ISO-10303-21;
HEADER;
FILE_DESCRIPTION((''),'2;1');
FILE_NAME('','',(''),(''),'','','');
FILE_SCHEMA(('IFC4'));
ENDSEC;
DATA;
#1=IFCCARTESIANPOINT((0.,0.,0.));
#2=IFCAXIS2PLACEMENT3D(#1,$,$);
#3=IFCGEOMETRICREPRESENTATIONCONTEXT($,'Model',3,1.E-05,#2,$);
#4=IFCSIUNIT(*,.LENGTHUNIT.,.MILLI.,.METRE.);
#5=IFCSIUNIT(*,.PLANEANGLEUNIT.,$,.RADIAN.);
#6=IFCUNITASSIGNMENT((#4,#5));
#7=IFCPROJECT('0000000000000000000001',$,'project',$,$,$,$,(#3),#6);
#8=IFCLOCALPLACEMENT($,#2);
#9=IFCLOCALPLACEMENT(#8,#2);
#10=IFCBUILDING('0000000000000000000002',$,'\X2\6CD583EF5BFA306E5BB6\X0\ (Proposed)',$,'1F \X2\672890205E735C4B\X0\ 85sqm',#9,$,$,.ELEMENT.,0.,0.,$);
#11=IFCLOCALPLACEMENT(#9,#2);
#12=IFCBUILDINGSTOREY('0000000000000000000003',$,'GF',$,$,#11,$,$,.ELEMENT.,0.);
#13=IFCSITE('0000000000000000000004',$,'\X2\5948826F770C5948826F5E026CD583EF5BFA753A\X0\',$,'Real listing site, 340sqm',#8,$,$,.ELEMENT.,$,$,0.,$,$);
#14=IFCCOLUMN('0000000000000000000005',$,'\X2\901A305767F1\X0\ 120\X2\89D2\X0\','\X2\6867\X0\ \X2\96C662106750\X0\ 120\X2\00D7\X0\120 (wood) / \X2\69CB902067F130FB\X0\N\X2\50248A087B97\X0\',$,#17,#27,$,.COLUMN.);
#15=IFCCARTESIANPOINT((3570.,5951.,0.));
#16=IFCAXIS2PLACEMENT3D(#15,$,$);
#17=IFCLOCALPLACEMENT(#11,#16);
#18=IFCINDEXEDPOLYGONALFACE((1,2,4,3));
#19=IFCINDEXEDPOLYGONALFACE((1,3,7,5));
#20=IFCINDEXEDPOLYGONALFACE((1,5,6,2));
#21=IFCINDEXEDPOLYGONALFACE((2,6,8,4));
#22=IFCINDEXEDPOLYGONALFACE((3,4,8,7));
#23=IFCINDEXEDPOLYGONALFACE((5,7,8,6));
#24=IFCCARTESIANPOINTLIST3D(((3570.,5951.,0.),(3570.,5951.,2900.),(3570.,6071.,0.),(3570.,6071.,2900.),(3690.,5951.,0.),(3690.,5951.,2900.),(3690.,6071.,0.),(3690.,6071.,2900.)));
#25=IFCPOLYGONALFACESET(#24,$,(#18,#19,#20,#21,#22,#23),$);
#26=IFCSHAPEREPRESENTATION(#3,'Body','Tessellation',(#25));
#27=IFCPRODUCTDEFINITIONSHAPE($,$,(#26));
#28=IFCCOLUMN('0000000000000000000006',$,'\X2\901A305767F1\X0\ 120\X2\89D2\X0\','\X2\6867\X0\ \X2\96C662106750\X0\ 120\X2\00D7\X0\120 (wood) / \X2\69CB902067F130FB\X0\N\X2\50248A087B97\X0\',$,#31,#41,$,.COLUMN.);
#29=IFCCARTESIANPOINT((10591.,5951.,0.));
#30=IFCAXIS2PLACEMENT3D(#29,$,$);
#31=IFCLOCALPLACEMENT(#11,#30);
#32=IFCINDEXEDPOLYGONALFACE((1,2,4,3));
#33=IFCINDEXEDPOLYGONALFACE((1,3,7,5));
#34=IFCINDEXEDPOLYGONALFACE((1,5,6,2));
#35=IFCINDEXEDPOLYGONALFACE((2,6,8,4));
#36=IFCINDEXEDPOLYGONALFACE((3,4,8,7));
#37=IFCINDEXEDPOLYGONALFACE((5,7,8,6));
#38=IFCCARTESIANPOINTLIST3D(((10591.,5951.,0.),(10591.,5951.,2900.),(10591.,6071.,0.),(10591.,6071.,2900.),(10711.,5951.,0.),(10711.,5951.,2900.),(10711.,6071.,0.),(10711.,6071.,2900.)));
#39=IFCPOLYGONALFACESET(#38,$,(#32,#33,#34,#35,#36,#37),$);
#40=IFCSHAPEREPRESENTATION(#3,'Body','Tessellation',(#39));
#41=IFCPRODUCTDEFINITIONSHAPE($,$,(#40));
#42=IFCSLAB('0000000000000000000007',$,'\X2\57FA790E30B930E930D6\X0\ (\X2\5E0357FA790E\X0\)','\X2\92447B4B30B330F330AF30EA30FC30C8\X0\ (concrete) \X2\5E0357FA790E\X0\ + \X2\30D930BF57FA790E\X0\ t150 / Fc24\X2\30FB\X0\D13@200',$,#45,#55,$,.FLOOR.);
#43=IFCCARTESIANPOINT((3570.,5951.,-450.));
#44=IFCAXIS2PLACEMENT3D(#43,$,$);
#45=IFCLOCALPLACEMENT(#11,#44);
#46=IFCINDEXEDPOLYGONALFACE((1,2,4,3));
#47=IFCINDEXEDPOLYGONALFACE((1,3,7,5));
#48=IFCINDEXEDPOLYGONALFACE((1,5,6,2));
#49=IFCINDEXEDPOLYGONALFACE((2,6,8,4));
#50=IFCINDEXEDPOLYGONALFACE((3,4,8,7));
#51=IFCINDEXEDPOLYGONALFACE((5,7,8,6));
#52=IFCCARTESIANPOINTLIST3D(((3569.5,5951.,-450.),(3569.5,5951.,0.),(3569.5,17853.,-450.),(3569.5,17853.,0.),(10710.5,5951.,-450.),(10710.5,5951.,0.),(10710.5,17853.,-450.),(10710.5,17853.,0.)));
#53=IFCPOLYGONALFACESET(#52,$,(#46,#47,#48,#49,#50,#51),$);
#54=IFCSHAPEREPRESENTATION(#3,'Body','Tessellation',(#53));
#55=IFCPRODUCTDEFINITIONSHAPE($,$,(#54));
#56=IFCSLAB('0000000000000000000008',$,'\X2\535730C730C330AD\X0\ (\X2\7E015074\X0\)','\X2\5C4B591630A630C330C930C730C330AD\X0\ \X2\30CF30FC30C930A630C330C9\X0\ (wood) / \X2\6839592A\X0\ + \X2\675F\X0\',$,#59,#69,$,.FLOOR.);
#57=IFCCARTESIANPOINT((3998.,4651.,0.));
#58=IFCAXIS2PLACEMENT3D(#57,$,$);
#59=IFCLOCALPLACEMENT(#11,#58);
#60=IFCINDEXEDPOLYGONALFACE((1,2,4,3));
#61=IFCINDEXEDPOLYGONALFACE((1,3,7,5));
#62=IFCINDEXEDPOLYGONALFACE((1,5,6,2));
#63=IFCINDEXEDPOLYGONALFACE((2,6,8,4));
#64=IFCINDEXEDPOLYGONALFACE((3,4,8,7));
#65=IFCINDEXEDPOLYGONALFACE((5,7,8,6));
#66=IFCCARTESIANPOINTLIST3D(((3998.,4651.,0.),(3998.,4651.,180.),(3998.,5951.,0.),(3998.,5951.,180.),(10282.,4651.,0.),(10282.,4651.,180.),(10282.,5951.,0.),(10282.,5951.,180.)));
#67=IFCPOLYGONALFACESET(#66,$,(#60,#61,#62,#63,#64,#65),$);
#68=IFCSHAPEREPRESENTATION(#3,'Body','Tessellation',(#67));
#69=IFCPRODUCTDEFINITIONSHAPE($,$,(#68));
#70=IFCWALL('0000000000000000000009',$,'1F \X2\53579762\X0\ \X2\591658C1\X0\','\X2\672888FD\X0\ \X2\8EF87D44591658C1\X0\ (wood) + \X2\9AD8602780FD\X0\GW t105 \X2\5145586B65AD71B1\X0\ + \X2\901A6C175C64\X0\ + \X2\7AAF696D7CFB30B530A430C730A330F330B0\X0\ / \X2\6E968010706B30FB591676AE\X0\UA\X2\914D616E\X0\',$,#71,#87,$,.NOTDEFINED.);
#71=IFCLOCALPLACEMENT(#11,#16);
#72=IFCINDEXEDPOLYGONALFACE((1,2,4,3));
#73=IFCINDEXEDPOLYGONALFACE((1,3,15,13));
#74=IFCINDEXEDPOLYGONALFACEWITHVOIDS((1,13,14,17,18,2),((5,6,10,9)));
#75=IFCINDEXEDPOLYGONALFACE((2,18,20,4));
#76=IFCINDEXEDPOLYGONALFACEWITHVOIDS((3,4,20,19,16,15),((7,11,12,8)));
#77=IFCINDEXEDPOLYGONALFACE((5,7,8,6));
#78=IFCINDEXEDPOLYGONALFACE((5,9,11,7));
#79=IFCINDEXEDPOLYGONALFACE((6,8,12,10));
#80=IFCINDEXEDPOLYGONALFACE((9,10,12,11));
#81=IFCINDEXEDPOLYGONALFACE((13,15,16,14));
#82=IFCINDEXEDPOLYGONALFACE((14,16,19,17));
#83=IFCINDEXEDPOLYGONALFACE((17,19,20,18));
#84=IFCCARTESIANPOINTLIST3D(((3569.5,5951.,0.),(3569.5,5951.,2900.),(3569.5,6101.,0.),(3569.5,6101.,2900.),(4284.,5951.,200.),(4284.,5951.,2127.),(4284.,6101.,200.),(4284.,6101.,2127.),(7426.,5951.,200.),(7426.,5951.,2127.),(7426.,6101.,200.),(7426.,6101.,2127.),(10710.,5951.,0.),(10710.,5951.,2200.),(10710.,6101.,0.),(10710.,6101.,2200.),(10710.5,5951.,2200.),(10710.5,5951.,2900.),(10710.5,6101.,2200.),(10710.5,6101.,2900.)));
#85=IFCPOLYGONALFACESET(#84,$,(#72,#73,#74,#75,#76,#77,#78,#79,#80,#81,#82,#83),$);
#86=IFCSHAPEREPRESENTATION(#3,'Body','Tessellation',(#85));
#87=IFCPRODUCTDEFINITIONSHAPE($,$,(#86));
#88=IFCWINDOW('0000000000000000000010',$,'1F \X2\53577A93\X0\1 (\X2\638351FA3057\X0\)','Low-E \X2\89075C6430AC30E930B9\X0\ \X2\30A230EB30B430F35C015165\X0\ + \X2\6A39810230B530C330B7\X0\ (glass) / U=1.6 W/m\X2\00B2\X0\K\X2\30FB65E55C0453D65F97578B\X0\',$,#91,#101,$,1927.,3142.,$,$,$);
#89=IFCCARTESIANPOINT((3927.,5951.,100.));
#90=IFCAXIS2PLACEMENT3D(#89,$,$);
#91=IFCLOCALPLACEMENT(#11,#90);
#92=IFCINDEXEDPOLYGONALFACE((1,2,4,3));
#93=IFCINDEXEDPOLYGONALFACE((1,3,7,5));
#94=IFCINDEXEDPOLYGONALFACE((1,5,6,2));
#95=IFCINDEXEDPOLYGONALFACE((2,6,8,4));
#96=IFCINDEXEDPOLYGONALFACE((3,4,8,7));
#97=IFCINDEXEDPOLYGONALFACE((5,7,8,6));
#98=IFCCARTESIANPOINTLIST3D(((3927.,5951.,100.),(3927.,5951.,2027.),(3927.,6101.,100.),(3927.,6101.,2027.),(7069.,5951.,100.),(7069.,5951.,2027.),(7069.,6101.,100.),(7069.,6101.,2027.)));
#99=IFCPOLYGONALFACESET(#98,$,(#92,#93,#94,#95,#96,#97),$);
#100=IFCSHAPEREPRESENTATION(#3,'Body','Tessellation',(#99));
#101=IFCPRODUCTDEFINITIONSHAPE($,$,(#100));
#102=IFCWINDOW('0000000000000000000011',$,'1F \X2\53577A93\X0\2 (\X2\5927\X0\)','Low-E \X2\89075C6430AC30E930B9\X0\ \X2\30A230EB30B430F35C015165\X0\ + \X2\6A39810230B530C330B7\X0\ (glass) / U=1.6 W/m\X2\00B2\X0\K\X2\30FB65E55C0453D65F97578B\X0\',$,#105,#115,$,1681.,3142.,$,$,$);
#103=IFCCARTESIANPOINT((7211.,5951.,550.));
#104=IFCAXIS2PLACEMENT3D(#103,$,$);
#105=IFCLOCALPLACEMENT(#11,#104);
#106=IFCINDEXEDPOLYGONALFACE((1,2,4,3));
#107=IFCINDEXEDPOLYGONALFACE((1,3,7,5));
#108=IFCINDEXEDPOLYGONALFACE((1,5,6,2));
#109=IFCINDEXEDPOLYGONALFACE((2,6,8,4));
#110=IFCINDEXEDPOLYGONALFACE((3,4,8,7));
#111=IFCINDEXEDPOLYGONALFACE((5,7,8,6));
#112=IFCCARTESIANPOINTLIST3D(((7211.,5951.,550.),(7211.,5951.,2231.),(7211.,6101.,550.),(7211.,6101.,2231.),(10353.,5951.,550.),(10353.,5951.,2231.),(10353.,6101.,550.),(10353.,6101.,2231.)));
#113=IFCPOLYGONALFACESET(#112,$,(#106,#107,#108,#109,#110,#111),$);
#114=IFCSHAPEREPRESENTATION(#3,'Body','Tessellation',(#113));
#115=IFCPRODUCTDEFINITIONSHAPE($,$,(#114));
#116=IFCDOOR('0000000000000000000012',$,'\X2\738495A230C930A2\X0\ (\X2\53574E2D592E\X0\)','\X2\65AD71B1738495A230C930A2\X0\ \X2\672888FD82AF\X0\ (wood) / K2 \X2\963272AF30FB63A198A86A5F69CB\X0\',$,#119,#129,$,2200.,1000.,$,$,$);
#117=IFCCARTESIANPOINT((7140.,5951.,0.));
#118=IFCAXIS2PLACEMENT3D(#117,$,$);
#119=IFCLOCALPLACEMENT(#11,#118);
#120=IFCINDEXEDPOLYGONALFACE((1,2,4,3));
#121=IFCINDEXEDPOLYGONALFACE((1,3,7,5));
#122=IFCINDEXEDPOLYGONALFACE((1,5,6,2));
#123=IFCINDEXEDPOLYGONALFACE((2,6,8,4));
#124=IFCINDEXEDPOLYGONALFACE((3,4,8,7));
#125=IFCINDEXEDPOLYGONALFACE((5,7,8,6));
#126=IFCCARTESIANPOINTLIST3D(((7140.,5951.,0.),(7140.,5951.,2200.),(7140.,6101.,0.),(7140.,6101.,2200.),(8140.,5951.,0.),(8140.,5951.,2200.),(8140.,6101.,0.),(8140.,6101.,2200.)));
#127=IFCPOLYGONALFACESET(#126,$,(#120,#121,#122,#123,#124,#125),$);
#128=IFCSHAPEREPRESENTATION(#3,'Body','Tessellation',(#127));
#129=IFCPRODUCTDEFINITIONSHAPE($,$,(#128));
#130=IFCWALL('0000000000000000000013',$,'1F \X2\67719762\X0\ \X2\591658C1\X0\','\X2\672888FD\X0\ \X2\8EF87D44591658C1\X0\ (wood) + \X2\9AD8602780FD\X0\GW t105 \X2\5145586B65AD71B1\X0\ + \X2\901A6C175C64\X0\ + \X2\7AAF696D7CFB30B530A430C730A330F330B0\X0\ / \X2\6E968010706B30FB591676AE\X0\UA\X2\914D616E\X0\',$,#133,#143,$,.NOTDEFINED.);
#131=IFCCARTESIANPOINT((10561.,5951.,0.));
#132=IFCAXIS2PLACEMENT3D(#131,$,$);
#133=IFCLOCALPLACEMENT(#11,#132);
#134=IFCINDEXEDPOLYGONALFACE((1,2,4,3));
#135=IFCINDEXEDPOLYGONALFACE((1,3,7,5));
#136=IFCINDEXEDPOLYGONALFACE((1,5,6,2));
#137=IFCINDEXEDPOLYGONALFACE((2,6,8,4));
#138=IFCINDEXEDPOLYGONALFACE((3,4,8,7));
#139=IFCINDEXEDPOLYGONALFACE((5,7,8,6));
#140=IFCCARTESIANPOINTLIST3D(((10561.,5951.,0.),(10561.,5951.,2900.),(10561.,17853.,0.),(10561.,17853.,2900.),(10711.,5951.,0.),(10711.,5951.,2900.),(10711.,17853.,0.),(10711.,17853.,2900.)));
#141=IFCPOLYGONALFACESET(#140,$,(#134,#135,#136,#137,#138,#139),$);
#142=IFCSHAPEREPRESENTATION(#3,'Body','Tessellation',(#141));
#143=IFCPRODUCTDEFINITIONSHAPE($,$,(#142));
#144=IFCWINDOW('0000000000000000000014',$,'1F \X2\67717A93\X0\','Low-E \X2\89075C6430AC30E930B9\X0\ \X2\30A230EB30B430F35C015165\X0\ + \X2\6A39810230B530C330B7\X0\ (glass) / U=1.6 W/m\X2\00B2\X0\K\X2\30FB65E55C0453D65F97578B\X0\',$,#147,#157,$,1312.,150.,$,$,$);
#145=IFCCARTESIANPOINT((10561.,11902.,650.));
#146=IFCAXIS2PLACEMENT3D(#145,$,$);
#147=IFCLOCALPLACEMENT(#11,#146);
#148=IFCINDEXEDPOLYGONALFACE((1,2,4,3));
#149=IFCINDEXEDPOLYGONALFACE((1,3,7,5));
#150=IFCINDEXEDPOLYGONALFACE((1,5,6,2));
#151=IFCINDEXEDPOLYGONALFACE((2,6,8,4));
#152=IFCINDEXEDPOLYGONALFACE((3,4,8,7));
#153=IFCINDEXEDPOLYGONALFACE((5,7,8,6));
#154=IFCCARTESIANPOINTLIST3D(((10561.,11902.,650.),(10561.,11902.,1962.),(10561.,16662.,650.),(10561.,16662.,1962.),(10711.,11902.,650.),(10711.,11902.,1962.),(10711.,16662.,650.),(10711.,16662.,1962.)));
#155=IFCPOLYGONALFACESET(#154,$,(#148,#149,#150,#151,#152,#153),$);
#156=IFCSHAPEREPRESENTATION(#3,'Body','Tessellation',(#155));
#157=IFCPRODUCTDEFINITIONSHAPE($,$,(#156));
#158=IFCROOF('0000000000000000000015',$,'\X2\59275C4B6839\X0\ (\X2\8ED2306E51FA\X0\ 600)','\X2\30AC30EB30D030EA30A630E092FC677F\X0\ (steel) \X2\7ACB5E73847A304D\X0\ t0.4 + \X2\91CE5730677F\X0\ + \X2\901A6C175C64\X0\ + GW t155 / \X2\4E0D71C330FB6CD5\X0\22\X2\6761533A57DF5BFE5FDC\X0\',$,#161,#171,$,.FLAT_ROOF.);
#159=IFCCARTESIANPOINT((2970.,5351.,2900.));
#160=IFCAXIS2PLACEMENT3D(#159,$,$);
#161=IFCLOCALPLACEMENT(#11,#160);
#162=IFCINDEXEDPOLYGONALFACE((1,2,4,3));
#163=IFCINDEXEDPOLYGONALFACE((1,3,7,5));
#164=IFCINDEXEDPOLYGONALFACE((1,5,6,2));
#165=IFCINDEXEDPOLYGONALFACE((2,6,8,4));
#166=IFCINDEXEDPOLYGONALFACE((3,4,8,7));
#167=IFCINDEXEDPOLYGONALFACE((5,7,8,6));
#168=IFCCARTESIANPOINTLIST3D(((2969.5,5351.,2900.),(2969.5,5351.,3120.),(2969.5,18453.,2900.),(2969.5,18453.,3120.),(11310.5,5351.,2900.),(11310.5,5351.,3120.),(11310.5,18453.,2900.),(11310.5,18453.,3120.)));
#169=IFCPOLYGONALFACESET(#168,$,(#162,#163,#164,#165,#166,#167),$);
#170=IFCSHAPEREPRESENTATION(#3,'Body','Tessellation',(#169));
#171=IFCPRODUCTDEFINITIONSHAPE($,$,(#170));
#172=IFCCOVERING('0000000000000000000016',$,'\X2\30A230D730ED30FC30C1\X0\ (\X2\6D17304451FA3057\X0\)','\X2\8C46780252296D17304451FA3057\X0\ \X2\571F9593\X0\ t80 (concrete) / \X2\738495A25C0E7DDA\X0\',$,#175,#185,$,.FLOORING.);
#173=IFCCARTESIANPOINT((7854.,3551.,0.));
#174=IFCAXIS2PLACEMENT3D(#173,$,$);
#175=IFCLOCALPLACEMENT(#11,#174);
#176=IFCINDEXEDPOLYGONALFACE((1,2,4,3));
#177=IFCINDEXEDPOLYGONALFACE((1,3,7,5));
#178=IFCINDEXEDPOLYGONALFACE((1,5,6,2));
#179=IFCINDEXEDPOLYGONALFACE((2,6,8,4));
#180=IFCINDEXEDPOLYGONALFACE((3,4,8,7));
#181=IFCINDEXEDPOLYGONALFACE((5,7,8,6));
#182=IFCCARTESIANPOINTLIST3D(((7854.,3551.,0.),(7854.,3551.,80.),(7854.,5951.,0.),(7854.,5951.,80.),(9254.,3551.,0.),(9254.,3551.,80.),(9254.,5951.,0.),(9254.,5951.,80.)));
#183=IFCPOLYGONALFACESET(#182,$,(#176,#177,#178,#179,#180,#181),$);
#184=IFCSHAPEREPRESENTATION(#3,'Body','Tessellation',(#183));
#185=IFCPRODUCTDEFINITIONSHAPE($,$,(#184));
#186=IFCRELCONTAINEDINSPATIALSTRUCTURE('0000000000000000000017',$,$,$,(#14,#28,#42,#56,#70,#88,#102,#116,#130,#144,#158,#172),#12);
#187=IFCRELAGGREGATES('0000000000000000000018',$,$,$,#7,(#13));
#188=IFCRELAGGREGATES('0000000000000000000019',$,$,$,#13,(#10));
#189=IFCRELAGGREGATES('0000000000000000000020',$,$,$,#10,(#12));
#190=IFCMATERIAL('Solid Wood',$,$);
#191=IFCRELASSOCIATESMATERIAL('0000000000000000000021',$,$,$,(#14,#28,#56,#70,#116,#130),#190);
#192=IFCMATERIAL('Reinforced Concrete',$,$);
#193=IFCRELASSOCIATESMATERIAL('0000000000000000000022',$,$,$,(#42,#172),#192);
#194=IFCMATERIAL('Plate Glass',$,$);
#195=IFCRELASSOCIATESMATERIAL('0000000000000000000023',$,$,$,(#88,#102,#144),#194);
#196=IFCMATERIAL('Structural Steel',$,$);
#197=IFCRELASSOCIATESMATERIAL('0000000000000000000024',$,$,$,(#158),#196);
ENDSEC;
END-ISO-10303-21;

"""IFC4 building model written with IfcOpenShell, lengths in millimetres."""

from ifc_helpers import new_model, si_unit, frame, frame_2d, origin, place, context, project, spatial, rectangle, extrude, material, element, fill, save


model = new_model("IFC4")

# Units and contexts
model_context = context("Model", 3, precision=1e-05, world=origin())
ifc_project = project(units=[si_unit("LENGTHUNIT", "METRE", prefix="MILLI"), si_unit("PLANEANGLEUNIT", "RADIAN")], contexts=[model_context])

# Site, building, storey
site_placement = place(None, origin())
site = spatial("IfcSite", under=ifc_project, at=site_placement, Name="奈良県奈良市法華寺町", ObjectType="Real listing site, 340sqm", CompositionType="ELEMENT", RefElevation=0.0)
building_placement = place(site_placement, origin())
building = spatial("IfcBuilding", under=site, at=building_placement, Name="法華寺の家 (Proposed)", ObjectType="1F 木造平屋 85sqm", CompositionType="ELEMENT", ElevationOfRefHeight=0.0, ElevationOfTerrain=0.0)
storey_placement = place(building_placement, origin())
storey = spatial("IfcBuildingStorey", under=building, at=storey_placement, Name="GF", CompositionType="ELEMENT", Elevation=0.0)

# Columns
ifc_material_1 = material(Name="Solid Wood")
column_1_placement = place(storey_placement, frame((3570.0, 5951.0, 0.0)))
element("IfcColumn", 1, at=column_1_placement, inside=storey, material=ifc_material_1, Name="通し柱 120角", Description="桧 集成材 120×120 (wood) / 構造柱・N値計算", PredefinedType="COLUMN", context=model_context, shape_type="SweptSolid", body=[
    extrude(rectangle(XDim=120.0, YDim=120.0, at=frame_2d((60.0, 60.0))), frame((3570.0, 5951.0, 0.0)), (0.0, 0.0, 1.0), 2900.0),
])
column_2_placement = place(storey_placement, frame((10591.0, 5951.0, 0.0)))
element("IfcColumn", 2, at=column_2_placement, inside=storey, material=ifc_material_1, Name="通し柱 120角", Description="桧 集成材 120×120 (wood) / 構造柱・N値計算", PredefinedType="COLUMN", context=model_context, shape_type="SweptSolid", body=[
    extrude(rectangle(XDim=120.0, YDim=120.0, at=frame_2d((60.0, 60.0))), frame((10591.0, 5951.0, 0.0)), (0.0, 0.0, 1.0), 2900.0),
])

# Slabs
ifc_material_2 = material(Name="Reinforced Concrete")
slab_1_placement = place(storey_placement, frame((3570.0, 5951.0, -450.0)))
element("IfcSlab", 3, at=slab_1_placement, inside=storey, material=ifc_material_2, Name="基礎スラブ (布基礎)", Description="鉄筋コンクリート (concrete) 布基礎 + ベタ基礎 t150 / Fc24・D13@200", PredefinedType="FLOOR", context=model_context, shape_type="SweptSolid", body=[
    extrude(rectangle(XDim=7141.0, YDim=11902.0, at=frame_2d((3570.0, 5951.0))), frame((3570.0, 5951.0, -450.0)), (0.0, 0.0, 1.0), 450.0),
])
slab_2_placement = place(storey_placement, frame((3998.0, 4651.0, 0.0)))
element("IfcSlab", 4, at=slab_2_placement, inside=storey, material=ifc_material_1, Name="南デッキ (縁側)", Description="屋外ウッドデッキ ハードウッド (wood) / 根太 + 束", PredefinedType="FLOOR", context=model_context, shape_type="SweptSolid", body=[
    extrude(rectangle(XDim=6284.0, YDim=1300.0, at=frame_2d((3142.0, 650.0))), frame((3998.0, 4651.0, 0.0)), (0.0, 0.0, 1.0), 180.0),
])

# Wall, openings, windows, door
wall_1_placement = place(storey_placement, frame((3570.0, 5951.0, 0.0)))
wall_1 = element("IfcWall", 5, at=wall_1_placement, inside=storey, material=ifc_material_1, Name="1F 南面 外壁", Description="木製 軸組外壁 (wood) + 高性能GW t105 充填断熱 + 通気層 + 窯業系サイディング / 準耐火・外皮UA配慮", PredefinedType="NOTDEFINED", context=model_context, shape_type="SweptSolid", body=[
    extrude(rectangle(XDim=7141.0, YDim=150.0, at=frame_2d((3570.0, 75.0))), frame((3570.0, 5951.0, 0.0)), (0.0, 0.0, 1.0), 2900.0),
])
opening_1_placement = place(storey_placement, frame((3927.0, 5951.0, 100.0)))
opening_1 = element("IfcOpeningElement", 6, at=opening_1_placement, cuts=wall_1, PredefinedType="NOTDEFINED", context=model_context, shape_type="SweptSolid", body=[
    extrude(rectangle(XDim=3142.0, YDim=150.0, at=frame_2d((1571.0, 75.0))), frame((3927.0, 5951.0, 100.0)), (0.0, 0.0, 1.0), 1927.0),
])
opening_2_placement = place(storey_placement, frame((7211.0, 5951.0, 550.0)))
opening_2 = element("IfcOpeningElement", 7, at=opening_2_placement, cuts=wall_1, PredefinedType="NOTDEFINED", context=model_context, shape_type="SweptSolid", body=[
    extrude(rectangle(XDim=3142.0, YDim=150.0, at=frame_2d((1571.0, 75.0))), frame((7211.0, 5951.0, 550.0)), (0.0, 0.0, 1.0), 1681.0),
])
opening_3_placement = place(storey_placement, frame((7140.0, 5951.0, 0.0)))
opening_3 = element("IfcOpeningElement", 8, at=opening_3_placement, cuts=wall_1, PredefinedType="NOTDEFINED", context=model_context, shape_type="SweptSolid", body=[
    extrude(rectangle(XDim=1000.0, YDim=150.0, at=frame_2d((500.0, 75.0))), frame((7140.0, 5951.0, 0.0)), (0.0, 0.0, 1.0), 2200.0),
])
ifc_material_3 = material(Name="Plate Glass")
window_1_placement = place(storey_placement, frame((3927.0, 5951.0, 100.0)))
window_1 = element("IfcWindow", 9, at=window_1_placement, inside=storey, material=ifc_material_3, Name="1F 南窓1 (掃出し)", Description="Low-E 複層ガラス アルゴン封入 + 樹脂サッシ (glass) / U=1.6 W/m²K・日射取得型", OverallHeight=1927.0, OverallWidth=3142.0, context=model_context, shape_type="SweptSolid", body=[
    extrude(rectangle(XDim=3142.0, YDim=150.0, at=frame_2d((1571.0, 75.0))), frame((3927.0, 5951.0, 100.0)), (0.0, 0.0, 1.0), 1927.0),
])
fill(opening_1, window_1)
window_2_placement = place(storey_placement, frame((7211.0, 5951.0, 550.0)))
window_2 = element("IfcWindow", 10, at=window_2_placement, inside=storey, material=ifc_material_3, Name="1F 南窓2 (大)", Description="Low-E 複層ガラス アルゴン封入 + 樹脂サッシ (glass) / U=1.6 W/m²K・日射取得型", OverallHeight=1681.0, OverallWidth=3142.0, context=model_context, shape_type="SweptSolid", body=[
    extrude(rectangle(XDim=3142.0, YDim=150.0, at=frame_2d((1571.0, 75.0))), frame((7211.0, 5951.0, 550.0)), (0.0, 0.0, 1.0), 1681.0),
])
fill(opening_2, window_2)
door_placement = place(storey_placement, frame((7140.0, 5951.0, 0.0)))
door = element("IfcDoor", 11, at=door_placement, inside=storey, material=ifc_material_1, Name="玄関ドア (南中央)", Description="断熱玄関ドア 木製芯 (wood) / K2 防犯・採風機構", OverallHeight=2200.0, OverallWidth=1000.0, context=model_context, shape_type="SweptSolid", body=[
    extrude(rectangle(XDim=1000.0, YDim=150.0, at=frame_2d((500.0, 75.0))), frame((7140.0, 5951.0, 0.0)), (0.0, 0.0, 1.0), 2200.0),
])
fill(opening_3, door)

# Wall, opening, window
wall_2_placement = place(storey_placement, frame((10561.0, 5951.0, 0.0)))
wall_2 = element("IfcWall", 12, at=wall_2_placement, inside=storey, material=ifc_material_1, Name="1F 東面 外壁", Description="木製 軸組外壁 (wood) + 高性能GW t105 充填断熱 + 通気層 + 窯業系サイディング / 準耐火・外皮UA配慮", PredefinedType="NOTDEFINED", context=model_context, shape_type="SweptSolid", body=[
    extrude(rectangle(XDim=150.0, YDim=11902.0, at=frame_2d((75.0, 5951.0))), frame((10561.0, 5951.0, 0.0)), (0.0, 0.0, 1.0), 2900.0),
])
opening_4_placement = place(storey_placement, frame((10561.0, 11902.0, 650.0)))
opening_4 = element("IfcOpeningElement", 13, at=opening_4_placement, cuts=wall_2, PredefinedType="NOTDEFINED", context=model_context, shape_type="SweptSolid", body=[
    extrude(rectangle(XDim=150.0, YDim=4760.0, at=frame_2d((75.0, 2380.0))), frame((10561.0, 11902.0, 650.0)), (0.0, 0.0, 1.0), 1312.0),
])
window_3_placement = place(storey_placement, frame((10561.0, 11902.0, 650.0)))
window_3 = element("IfcWindow", 14, at=window_3_placement, inside=storey, material=ifc_material_3, Name="1F 東窓", Description="Low-E 複層ガラス アルゴン封入 + 樹脂サッシ (glass) / U=1.6 W/m²K・日射取得型", OverallHeight=1312.0, OverallWidth=150.0, context=model_context, shape_type="SweptSolid", body=[
    extrude(rectangle(XDim=150.0, YDim=4760.0, at=frame_2d((75.0, 2380.0))), frame((10561.0, 11902.0, 650.0)), (0.0, 0.0, 1.0), 1312.0),
])
fill(opening_4, window_3)

# Roof
ifc_material_4 = material(Name="Structural Steel")
roof_placement = place(storey_placement, frame((2970.0, 5351.0, 2900.0)))
element("IfcRoof", 15, at=roof_placement, inside=storey, material=ifc_material_4, Name="大屋根 (軒の出 600)", Description="ガルバリウム鋼板 (steel) 立平葺き t0.4 + 野地板 + 通気層 + GW t155 / 不燃・法22条区域対応", PredefinedType="FLAT_ROOF", context=model_context, shape_type="SweptSolid", body=[
    extrude(rectangle(XDim=8341.0, YDim=13102.0, at=frame_2d((4170.0, 6551.0))), frame((2970.0, 5351.0, 2900.0)), (0.0, 0.0, 1.0), 220.0),
])

# Covering
covering_1_placement = place(storey_placement, frame((7854.0, 3551.0, 0.0)))
element("IfcCovering", 16, at=covering_1_placement, inside=storey, material=ifc_material_2, Name="アプローチ (洗い出し)", Description="豆砂利洗い出し 土間 t80 (concrete) / 玄関導線", PredefinedType="FLOORING", context=model_context, shape_type="SweptSolid", body=[
    extrude(rectangle(XDim=1400.0, YDim=2400.0, at=frame_2d((700.0, 1200.0))), frame((7854.0, 3551.0, 0.0)), (0.0, 0.0, 1.0), 80.0),
])

save(model, "model.ifc")
